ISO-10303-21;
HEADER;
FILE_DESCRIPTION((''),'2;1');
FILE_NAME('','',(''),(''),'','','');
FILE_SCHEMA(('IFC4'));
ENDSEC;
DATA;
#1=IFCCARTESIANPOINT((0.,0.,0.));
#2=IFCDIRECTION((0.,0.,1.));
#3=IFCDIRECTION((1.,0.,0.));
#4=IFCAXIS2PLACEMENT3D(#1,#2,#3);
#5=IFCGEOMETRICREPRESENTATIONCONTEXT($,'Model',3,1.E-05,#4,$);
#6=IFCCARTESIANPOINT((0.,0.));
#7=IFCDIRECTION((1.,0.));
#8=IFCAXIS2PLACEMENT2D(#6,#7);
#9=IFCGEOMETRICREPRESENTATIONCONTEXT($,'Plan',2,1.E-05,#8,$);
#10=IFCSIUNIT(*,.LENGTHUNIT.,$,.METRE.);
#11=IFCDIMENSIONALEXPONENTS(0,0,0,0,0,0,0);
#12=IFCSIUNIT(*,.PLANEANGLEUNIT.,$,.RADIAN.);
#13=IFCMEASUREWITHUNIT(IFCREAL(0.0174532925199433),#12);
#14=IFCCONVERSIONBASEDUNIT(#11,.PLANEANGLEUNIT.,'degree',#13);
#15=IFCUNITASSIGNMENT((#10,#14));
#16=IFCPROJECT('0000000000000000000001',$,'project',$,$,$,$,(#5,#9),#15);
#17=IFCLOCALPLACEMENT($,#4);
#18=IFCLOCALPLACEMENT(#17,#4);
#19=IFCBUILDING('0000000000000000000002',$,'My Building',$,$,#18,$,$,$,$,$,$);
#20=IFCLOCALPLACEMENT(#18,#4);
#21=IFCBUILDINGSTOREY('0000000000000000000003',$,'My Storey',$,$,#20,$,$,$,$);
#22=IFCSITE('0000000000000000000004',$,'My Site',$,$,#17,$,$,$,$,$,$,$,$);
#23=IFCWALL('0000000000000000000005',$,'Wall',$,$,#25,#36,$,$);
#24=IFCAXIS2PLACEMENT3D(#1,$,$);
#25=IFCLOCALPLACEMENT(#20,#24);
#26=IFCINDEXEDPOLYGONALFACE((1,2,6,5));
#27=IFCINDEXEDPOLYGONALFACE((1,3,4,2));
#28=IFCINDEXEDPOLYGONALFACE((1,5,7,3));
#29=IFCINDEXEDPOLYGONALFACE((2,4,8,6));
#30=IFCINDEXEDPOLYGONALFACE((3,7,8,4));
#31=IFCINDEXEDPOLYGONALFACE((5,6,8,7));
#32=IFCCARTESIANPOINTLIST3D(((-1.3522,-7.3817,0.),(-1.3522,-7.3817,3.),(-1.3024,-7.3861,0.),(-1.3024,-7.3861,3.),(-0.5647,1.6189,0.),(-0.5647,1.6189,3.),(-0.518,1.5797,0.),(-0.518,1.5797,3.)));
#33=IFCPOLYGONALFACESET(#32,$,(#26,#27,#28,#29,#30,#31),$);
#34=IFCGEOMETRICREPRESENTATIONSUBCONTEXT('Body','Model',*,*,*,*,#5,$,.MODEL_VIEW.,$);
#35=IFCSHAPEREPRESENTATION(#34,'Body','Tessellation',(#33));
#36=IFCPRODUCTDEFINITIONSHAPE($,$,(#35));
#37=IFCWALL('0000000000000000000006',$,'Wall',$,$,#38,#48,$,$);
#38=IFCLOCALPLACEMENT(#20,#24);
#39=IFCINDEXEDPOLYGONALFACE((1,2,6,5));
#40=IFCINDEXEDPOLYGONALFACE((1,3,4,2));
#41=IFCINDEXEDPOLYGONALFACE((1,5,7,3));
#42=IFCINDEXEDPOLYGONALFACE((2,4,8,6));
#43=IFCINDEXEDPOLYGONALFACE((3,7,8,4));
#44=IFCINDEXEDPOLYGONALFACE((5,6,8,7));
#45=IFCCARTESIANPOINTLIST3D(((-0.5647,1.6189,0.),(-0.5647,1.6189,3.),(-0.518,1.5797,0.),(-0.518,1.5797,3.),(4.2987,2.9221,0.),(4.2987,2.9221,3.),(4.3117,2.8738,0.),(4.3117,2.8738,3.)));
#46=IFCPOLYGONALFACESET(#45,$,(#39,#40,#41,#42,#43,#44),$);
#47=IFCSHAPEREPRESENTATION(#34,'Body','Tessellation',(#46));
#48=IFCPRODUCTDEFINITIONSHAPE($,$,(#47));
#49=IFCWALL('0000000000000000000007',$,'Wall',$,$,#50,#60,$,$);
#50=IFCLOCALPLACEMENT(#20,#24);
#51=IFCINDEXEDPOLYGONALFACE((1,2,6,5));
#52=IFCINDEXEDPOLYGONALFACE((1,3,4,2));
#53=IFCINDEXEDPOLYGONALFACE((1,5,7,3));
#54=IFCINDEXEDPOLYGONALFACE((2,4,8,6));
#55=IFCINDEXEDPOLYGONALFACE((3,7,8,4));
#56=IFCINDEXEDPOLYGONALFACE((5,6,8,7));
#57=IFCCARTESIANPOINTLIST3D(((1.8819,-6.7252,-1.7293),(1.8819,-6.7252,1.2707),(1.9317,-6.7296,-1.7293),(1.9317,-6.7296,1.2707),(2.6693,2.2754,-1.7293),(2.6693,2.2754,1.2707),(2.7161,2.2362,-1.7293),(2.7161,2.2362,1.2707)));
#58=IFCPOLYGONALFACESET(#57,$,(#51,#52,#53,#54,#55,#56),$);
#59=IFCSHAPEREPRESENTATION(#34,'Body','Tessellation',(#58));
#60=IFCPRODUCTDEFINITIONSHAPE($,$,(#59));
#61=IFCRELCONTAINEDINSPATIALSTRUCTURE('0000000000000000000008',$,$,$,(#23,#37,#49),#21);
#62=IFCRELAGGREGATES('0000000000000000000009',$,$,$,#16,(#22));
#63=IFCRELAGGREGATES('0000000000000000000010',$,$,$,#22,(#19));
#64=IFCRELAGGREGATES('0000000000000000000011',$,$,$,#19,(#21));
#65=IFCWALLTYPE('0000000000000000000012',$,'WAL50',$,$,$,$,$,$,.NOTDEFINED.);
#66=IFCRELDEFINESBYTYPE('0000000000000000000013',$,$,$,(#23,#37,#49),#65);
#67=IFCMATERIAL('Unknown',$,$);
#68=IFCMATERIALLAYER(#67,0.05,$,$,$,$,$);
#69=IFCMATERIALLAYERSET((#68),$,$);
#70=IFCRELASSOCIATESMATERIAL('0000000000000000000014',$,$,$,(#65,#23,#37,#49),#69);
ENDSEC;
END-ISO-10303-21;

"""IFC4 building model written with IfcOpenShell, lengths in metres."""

from ifc_helpers import new_model, entity, si_unit, converted_unit, frame, origin_with_axes, origin_2d_with_axis, place, context, subcontext, project, spatial, line, indexed_curve, outline, extrude, material, layer, layer_set, layer_usage, type_object, element, save


model = new_model("IFC4")

# Units and contexts
model_context = context("Model", 3, precision=1e-05, world=origin_with_axes())
plan_context = context("Plan", 2, precision=1e-05, world=origin_2d_with_axis())
body_context = subcontext(model_context, "Body", "Model", "MODEL_VIEW")
ifc_project = project(units=[si_unit("LENGTHUNIT", "METRE"), converted_unit("PLANEANGLEUNIT", "degree", entity("IfcReal", 0.0174532925199433), si_unit("PLANEANGLEUNIT", "RADIAN"), dimensions=[0, 0, 0, 0, 0, 0, 0])], contexts=[model_context, plan_context])

# Site, building, storey
site_placement = place(None, origin_with_axes())
site = spatial("IfcSite", under=ifc_project, at=site_placement, Name="My Site")
building_placement = place(site_placement, origin_with_axes())
building = spatial("IfcBuilding", under=site, at=building_placement, Name="My Building")
storey_placement = place(building_placement, origin_with_axes())
storey = spatial("IfcBuildingStorey", under=building, at=storey_placement, Name="My Storey")

# Walls
ifc_material = material(Name="Unknown")
ifc_layer = layer(ifc_material, 0.05)
ifc_layer_set = layer_set([ifc_layer])
ifc_layer_usage_1 = layer_usage(ifc_layer_set, "AXIS2", "POSITIVE", 0.0)
wall_type = type_object("IfcWallType", Name="WAL50", PredefinedType="NOTDEFINED", material=ifc_layer_set)
wall_1_placement = place(storey_placement, frame((-1.3024, -7.3861, 0.0), z_axis=(0.0, 0.0, 1.0), x_axis=(0.087156, 0.996195, 0.0)))
element("IfcWall", 1, at=wall_1_placement, inside=storey, type_object=wall_type, material=ifc_layer_usage_1, Name="Wall", context=body_context, shape_type="SweptSolid", body=[
    extrude(outline(indexed_curve([(0.0, 0.0), (0.0, 0.05), (9.035, 0.05), (9.0, 0.0)], segments=[line(1, 2, 3, 4, 1)])), origin_with_axes(), (0.0, 0.0, 1.0), 3.0),
])
ifc_layer_usage_2 = layer_usage(ifc_layer_set, "AXIS2", "POSITIVE", 0.0)
wall_2_placement = place(storey_placement, frame((-0.518, 1.5797, 0.0), z_axis=(0.0, 0.0, 1.0), x_axis=(0.965926, 0.258819, 0.0)))
element("IfcWall", 2, at=wall_2_placement, inside=storey, type_object=wall_type, material=ifc_layer_usage_2, Name="Wall", context=body_context, shape_type="SweptSolid", body=[
    extrude(outline(indexed_curve([(0.0, 0.0), (-0.035, 0.05), (5.0, 0.05), (5.0, 0.0)], segments=[line(1, 2, 3, 4, 1)])), origin_with_axes(), (0.0, 0.0, 1.0), 3.0),
])
ifc_layer_usage_3 = layer_usage(ifc_layer_set, "AXIS2", "POSITIVE", 0.0)
wall_3_placement = place(storey_placement, frame((1.9317, -6.7296, -1.7293), z_axis=(0.0, 0.0, 1.0), x_axis=(0.087156, 0.996195, 0.0)))
element("IfcWall", 3, at=wall_3_placement, inside=storey, type_object=wall_type, material=ifc_layer_usage_3, Name="Wall", context=body_context, shape_type="SweptSolid", body=[
    extrude(outline(indexed_curve([(0.0, 0.0), (0.0, 0.05), (9.035, 0.05), (9.0, 0.0)], segments=[line(1, 2, 3, 4, 1)])), origin_with_axes(), (0.0, 0.0, 1.0), 3.0),
])

save(model, "model.ifc")
